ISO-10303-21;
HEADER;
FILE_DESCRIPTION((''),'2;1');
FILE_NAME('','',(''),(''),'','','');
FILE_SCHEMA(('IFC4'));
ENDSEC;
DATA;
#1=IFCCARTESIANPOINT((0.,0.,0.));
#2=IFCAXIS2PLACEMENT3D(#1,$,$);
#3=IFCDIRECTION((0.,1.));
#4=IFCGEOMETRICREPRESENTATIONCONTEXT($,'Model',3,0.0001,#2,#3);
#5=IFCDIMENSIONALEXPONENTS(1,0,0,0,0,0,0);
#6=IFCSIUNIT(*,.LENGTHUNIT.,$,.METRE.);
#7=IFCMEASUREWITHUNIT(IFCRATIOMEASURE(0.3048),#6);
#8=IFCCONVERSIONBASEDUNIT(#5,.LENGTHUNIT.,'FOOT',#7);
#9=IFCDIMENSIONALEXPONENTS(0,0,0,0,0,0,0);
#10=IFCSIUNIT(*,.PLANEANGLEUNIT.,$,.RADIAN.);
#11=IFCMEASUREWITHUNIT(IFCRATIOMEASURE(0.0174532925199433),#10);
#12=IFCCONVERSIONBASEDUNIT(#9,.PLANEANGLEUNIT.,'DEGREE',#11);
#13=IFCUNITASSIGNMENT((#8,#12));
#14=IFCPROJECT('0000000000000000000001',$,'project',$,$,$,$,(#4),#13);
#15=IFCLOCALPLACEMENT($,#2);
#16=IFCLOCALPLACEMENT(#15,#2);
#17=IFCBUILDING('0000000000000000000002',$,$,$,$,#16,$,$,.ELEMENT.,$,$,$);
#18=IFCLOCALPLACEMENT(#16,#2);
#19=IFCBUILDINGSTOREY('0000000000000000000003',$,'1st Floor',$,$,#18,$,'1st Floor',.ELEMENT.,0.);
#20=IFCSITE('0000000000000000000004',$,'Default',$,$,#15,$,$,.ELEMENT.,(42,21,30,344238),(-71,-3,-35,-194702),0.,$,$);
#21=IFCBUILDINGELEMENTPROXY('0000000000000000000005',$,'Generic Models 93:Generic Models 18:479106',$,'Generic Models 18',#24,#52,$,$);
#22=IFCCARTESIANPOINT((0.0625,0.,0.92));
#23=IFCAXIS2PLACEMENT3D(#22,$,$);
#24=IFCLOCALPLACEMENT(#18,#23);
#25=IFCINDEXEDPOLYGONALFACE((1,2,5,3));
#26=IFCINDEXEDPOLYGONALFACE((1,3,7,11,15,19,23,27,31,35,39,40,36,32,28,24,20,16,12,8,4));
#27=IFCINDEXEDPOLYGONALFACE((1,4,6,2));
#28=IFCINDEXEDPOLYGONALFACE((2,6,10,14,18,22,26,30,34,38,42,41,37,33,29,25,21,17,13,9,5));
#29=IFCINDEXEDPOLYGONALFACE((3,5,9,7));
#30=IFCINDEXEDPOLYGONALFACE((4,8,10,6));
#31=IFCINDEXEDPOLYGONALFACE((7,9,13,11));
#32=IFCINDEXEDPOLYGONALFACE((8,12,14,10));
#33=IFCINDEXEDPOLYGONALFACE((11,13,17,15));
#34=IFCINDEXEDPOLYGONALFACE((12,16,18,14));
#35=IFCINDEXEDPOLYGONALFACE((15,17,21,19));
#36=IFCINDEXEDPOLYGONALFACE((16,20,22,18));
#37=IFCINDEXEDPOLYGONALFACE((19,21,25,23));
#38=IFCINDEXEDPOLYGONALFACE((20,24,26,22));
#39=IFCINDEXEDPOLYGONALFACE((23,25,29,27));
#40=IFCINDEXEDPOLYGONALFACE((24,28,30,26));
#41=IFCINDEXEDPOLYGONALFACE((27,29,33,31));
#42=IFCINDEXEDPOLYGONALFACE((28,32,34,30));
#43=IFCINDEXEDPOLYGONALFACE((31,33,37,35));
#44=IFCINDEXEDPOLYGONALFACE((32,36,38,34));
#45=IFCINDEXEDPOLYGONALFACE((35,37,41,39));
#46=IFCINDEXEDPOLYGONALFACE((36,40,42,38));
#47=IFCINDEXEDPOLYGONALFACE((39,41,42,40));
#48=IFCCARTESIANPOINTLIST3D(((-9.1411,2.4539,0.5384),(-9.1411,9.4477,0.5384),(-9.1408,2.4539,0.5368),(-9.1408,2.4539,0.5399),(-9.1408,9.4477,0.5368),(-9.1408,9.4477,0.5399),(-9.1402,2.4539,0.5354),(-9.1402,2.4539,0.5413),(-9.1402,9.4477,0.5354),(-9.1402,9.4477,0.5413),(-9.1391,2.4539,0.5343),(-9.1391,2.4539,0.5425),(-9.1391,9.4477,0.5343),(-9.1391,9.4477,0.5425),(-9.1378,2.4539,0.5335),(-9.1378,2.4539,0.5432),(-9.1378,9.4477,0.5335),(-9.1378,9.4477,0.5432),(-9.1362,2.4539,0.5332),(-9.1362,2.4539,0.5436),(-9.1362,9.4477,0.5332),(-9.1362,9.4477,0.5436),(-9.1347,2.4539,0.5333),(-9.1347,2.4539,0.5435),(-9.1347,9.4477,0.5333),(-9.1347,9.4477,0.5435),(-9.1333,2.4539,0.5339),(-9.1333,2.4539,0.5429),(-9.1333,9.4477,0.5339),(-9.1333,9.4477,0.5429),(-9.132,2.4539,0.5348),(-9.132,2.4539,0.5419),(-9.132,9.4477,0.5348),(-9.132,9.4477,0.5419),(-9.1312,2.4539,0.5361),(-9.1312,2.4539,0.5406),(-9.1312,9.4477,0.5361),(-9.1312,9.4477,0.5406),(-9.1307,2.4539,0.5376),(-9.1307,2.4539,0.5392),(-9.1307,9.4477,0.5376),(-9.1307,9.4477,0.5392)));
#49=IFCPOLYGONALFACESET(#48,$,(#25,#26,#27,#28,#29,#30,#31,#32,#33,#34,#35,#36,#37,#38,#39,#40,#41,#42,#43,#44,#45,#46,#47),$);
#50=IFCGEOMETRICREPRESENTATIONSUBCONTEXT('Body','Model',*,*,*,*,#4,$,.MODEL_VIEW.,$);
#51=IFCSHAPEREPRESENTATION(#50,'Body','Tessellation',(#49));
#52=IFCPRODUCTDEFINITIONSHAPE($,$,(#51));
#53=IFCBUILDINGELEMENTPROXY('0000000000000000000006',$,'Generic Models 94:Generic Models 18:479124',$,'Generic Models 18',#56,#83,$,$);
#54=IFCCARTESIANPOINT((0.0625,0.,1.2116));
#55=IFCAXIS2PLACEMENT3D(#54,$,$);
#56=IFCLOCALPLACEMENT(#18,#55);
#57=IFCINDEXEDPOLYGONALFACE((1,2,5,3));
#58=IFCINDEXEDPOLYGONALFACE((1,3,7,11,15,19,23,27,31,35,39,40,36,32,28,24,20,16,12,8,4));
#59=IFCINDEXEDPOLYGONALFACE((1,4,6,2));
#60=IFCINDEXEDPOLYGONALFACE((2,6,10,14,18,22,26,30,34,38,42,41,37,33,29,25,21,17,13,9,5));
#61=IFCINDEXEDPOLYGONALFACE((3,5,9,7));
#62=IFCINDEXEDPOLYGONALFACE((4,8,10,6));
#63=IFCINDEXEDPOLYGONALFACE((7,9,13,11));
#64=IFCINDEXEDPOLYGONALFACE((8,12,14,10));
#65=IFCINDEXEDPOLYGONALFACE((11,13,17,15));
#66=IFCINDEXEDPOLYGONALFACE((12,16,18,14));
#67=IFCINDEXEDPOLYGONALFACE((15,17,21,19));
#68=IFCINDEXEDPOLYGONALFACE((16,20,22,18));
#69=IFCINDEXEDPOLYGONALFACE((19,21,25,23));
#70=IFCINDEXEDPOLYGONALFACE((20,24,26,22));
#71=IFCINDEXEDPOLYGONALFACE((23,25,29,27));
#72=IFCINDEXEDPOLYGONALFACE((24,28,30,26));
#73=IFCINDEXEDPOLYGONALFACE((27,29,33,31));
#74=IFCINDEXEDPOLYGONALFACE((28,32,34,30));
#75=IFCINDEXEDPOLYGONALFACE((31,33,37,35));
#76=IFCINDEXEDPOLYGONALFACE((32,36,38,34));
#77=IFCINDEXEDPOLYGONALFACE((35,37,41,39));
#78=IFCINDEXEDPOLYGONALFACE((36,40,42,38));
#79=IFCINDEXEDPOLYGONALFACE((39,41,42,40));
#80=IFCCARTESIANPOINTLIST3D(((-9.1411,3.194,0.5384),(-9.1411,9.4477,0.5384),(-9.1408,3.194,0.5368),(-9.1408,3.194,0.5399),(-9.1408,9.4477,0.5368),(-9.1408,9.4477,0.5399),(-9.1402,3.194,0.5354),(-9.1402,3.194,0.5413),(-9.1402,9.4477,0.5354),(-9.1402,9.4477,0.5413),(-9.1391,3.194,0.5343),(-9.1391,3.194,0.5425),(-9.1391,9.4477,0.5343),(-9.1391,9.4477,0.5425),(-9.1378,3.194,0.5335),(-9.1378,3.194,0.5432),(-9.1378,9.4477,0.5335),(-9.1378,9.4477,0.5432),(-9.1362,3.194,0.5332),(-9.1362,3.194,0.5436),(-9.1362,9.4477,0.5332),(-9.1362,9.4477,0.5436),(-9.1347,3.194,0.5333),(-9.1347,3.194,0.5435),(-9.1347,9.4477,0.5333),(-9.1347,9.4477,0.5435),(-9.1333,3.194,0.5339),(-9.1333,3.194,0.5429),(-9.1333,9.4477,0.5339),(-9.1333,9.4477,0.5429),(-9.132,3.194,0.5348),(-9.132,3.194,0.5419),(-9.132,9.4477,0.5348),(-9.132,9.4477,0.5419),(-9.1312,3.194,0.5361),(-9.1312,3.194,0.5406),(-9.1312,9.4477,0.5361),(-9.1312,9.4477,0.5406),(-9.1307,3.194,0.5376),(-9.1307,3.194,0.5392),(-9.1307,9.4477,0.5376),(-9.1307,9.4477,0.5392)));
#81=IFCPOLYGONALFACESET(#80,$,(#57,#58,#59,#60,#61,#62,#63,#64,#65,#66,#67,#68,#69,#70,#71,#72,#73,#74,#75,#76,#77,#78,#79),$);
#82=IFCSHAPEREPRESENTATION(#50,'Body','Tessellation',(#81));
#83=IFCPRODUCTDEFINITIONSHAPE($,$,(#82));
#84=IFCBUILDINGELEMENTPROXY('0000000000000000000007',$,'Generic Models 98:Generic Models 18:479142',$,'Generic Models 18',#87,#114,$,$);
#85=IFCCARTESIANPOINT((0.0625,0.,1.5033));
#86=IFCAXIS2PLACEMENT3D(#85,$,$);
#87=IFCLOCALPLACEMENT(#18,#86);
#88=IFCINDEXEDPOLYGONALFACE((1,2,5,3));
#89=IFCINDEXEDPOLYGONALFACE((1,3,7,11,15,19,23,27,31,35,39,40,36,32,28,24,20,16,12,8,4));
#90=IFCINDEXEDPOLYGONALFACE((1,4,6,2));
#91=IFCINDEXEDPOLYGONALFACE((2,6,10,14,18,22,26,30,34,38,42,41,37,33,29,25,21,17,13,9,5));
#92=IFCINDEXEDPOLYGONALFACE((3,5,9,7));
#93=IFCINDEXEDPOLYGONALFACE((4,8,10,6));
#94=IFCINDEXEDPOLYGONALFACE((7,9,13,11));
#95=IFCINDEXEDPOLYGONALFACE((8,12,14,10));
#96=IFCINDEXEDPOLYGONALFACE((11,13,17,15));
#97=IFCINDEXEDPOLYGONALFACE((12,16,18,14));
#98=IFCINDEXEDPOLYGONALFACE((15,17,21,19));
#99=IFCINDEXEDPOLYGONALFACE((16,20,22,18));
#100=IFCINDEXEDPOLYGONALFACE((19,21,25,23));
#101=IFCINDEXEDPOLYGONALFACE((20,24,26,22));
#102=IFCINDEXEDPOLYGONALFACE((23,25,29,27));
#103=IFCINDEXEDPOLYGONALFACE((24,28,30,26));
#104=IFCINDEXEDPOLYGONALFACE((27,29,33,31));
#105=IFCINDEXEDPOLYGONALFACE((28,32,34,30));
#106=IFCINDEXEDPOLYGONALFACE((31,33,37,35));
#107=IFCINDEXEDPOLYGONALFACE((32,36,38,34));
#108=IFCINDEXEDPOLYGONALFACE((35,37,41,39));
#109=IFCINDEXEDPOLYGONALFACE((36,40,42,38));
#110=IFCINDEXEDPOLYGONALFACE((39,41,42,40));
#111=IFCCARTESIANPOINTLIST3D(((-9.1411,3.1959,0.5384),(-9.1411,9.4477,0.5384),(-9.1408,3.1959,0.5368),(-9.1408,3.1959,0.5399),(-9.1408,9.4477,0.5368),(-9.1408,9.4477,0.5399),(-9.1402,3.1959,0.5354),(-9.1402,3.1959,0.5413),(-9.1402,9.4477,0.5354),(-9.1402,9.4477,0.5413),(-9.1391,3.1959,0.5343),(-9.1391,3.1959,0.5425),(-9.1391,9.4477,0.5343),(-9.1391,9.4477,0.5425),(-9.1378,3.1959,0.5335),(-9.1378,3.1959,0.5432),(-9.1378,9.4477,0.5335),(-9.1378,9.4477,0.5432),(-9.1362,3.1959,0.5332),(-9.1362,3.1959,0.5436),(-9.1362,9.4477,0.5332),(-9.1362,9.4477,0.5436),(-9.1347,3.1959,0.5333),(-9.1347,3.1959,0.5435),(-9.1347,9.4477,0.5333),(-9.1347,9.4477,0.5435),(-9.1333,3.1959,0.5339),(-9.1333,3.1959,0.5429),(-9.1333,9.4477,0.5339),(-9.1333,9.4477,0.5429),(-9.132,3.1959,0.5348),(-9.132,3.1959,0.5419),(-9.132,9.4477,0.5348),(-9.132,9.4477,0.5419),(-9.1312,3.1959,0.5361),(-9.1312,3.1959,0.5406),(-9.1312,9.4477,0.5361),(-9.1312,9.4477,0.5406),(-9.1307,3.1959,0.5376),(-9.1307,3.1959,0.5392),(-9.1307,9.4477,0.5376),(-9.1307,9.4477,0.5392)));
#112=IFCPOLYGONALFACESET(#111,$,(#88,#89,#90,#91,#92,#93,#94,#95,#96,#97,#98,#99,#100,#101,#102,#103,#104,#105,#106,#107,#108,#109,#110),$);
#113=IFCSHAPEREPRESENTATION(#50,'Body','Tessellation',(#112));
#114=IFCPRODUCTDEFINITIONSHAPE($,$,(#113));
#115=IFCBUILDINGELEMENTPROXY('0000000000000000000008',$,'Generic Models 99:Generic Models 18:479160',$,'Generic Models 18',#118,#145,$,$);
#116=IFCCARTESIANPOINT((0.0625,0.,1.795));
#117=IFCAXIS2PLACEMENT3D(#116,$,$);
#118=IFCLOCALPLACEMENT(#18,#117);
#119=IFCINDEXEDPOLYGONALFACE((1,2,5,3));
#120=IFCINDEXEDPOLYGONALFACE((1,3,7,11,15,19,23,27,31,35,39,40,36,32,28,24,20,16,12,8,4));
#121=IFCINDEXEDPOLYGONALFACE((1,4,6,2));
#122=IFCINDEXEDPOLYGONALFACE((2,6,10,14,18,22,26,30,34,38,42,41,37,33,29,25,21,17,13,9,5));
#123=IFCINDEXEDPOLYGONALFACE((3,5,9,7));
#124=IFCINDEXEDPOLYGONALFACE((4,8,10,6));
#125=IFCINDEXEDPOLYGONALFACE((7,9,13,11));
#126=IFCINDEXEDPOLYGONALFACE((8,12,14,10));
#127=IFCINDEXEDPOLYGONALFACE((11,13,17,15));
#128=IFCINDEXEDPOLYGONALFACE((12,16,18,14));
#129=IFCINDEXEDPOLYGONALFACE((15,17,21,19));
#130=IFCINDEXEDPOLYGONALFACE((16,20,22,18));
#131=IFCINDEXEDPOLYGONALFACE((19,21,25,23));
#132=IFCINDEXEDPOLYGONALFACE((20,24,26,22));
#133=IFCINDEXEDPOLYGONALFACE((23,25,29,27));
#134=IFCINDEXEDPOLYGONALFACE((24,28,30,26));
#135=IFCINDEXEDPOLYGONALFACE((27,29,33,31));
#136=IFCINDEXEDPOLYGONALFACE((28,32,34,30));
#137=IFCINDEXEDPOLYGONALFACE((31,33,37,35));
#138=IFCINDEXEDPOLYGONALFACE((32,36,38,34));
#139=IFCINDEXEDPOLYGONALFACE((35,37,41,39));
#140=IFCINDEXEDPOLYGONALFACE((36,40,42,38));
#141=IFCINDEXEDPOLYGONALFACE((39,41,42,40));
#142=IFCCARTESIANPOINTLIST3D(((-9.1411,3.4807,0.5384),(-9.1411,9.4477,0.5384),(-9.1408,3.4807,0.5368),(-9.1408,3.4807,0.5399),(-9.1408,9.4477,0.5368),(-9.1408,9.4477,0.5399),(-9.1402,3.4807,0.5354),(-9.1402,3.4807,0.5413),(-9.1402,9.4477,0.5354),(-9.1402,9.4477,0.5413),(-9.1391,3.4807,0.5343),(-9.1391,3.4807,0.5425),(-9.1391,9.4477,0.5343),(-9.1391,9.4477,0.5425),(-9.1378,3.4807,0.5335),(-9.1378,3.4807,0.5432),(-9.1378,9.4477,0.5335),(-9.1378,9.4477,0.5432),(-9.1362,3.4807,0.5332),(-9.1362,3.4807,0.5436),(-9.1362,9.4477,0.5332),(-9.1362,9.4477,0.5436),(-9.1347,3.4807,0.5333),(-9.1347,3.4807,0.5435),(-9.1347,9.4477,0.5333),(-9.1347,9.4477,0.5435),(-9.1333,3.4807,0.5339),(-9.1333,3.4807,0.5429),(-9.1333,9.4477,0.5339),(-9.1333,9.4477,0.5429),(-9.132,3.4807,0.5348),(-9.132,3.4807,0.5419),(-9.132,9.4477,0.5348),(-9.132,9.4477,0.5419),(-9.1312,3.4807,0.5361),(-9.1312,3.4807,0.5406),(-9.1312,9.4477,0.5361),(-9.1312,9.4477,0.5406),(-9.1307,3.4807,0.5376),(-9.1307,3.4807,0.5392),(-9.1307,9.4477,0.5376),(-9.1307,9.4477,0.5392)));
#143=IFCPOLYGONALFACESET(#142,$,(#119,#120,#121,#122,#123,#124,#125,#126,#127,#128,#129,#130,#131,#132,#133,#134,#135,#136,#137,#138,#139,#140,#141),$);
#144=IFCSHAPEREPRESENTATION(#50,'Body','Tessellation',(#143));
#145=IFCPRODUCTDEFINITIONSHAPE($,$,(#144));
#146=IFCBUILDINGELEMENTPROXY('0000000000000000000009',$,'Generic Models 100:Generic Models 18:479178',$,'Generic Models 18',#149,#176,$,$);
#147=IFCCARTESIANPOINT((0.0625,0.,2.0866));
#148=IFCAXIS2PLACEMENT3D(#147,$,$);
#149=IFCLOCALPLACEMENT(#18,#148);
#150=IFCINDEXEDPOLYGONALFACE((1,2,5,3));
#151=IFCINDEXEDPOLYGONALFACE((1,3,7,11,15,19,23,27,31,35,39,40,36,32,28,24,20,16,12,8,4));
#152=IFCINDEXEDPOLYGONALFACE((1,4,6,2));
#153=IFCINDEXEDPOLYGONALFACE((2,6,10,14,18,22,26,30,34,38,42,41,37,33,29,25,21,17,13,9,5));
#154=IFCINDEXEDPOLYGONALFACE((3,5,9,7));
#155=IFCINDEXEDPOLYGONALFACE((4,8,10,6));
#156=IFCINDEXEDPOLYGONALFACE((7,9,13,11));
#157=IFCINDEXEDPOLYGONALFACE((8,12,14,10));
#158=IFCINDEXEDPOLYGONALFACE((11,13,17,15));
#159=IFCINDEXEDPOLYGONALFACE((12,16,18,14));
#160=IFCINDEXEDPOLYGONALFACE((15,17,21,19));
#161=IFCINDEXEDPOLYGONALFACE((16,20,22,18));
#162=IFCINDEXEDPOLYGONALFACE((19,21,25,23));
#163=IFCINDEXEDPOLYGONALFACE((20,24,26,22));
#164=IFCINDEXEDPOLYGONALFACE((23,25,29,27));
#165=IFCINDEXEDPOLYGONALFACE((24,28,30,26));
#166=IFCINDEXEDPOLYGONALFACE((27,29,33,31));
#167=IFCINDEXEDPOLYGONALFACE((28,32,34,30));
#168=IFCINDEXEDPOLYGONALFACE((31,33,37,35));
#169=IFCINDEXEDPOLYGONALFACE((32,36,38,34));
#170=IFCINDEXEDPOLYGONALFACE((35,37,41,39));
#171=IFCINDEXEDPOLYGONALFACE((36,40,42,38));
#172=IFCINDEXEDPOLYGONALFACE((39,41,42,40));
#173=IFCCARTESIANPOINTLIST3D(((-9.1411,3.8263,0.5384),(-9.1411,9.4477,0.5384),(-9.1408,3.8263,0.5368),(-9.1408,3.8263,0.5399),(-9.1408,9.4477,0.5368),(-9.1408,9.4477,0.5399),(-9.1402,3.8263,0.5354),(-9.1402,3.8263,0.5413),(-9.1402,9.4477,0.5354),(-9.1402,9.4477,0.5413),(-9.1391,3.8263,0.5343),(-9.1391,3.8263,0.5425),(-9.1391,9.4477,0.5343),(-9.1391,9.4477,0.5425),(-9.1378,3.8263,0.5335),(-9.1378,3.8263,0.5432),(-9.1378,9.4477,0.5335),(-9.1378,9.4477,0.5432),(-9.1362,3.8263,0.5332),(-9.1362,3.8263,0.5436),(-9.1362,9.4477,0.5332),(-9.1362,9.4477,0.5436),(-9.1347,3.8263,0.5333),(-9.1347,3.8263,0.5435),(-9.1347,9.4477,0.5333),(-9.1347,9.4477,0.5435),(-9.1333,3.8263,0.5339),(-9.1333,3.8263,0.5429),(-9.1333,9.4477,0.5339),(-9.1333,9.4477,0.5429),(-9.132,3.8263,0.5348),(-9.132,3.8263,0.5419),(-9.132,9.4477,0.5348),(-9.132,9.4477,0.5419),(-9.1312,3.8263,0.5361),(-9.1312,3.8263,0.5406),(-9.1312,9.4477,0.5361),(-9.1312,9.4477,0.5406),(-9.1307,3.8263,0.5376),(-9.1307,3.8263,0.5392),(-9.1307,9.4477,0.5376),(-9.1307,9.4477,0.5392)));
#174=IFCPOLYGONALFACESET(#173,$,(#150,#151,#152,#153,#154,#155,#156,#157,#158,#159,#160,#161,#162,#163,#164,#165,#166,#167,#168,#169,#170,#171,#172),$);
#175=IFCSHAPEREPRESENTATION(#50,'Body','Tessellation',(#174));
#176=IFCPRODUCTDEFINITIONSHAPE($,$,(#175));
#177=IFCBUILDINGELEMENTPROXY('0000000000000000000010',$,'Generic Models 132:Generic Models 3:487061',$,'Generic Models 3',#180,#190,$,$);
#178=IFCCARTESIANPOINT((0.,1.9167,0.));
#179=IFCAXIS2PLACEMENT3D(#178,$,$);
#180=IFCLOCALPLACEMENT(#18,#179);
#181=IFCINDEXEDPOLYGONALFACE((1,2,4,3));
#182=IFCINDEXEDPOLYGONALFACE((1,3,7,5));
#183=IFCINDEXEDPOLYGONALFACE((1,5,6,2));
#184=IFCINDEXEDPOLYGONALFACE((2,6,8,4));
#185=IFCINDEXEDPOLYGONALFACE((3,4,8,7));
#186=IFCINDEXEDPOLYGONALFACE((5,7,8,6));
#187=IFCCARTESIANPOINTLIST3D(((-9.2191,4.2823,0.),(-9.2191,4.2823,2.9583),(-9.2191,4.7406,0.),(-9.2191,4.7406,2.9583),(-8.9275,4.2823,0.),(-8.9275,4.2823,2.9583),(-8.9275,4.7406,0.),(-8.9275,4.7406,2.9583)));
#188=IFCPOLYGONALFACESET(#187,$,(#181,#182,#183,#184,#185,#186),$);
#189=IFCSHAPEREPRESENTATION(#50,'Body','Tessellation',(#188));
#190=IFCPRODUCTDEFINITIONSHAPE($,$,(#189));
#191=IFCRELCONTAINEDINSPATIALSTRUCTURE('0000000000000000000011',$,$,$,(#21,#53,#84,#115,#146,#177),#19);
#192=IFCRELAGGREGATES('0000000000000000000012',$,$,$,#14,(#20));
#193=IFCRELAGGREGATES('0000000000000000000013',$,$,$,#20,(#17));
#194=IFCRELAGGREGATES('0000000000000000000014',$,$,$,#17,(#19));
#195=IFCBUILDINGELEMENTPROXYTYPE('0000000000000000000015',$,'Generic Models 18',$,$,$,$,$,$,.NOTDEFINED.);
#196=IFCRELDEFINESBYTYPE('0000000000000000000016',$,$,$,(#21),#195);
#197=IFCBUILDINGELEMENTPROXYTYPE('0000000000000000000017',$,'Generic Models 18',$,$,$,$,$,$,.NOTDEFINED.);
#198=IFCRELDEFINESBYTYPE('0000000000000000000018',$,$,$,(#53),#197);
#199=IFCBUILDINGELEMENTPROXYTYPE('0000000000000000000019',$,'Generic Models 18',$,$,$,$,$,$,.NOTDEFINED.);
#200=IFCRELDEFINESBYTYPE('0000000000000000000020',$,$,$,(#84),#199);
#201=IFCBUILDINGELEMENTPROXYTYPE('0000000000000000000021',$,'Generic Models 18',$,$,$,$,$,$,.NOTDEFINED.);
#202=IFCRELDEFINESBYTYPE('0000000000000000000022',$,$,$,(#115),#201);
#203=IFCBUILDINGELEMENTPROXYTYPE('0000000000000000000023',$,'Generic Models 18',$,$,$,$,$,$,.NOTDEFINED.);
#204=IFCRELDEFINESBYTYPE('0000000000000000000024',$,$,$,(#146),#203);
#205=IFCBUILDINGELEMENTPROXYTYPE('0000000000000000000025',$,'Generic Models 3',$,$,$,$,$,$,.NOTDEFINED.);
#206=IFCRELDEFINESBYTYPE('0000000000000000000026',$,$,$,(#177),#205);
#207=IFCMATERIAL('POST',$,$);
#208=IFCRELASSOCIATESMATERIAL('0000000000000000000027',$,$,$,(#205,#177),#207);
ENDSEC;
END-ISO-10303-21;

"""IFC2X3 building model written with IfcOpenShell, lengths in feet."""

from ifc_helpers import new_model, entity, si_unit, converted_unit, direction, frame, frame_2d, origin, origin_2d_with_axis, place, context, subcontext, project, spatial, rectangle, circle, extrude, source, transform, mapped, material, type_object, type_shapes, element, save


model = new_model("IFC2X3")

# Units and contexts
model_context = context("Model", 3, precision=0.0001, world=origin(), true_north=direction((0.0, 1.0)))
body_context = subcontext(model_context, "Body", "Model", "MODEL_VIEW")
ifc_project = project(units=[converted_unit("LENGTHUNIT", "FOOT", entity("IfcRatioMeasure", 0.3048), si_unit("LENGTHUNIT", "METRE"), dimensions=[1, 0, 0, 0, 0, 0, 0]), converted_unit("PLANEANGLEUNIT", "DEGREE", entity("IfcRatioMeasure", 0.0174532925199433), si_unit("PLANEANGLEUNIT", "RADIAN"), dimensions=[0, 0, 0, 0, 0, 0, 0])], contexts=[model_context])

# Site, building, storey
site_placement = place(None, origin())
site = spatial("IfcSite", under=ifc_project, at=site_placement, Name="Default", CompositionType="ELEMENT", RefLatitude=(42, 21, 30, 344238), RefLongitude=(-71, -3, -35, -194702), RefElevation=0.0)
building_placement = place(site_placement, origin())
building = spatial("IfcBuilding", under=site, at=building_placement, CompositionType="ELEMENT")
storey_placement = place(building_placement, origin())
storey = spatial("IfcBuildingStorey", under=building, at=storey_placement, Name="1st Floor", LongName="1st Floor", CompositionType="ELEMENT", Elevation=0.0)

# Building element proxies
building_element_proxy_type_1 = type_object("IfcBuildingElementProxyType", Name="Generic Models 18", PredefinedType="NOTDEFINED")
shared_shape_1 = source(origin(), body_context, "Body", "SweptSolid", [
    extrude(circle(Radius=0.0052, at=origin_2d_with_axis()), frame((-9.1359, 2.4539, 0.5384), z_axis=(0.0, 1.0, 0.0), x_axis=(-1.0, 0.0, 0.0)), (0.0, 0.0, 1.0), 6.9938),
])
type_shapes(building_element_proxy_type_1, [shared_shape_1])
proxy_1_placement = place(storey_placement, frame((0.0625, 0.0, 0.92)))
element("IfcBuildingElementProxy", 1, at=proxy_1_placement, inside=storey, type_object=building_element_proxy_type_1, Name="Generic Models 93:Generic Models 18:479106", ObjectType="Generic Models 18", context=body_context, shape_type="MappedRepresentation", body=[
    mapped(shared_shape_1, transform((0.0, 0.0, 0.0), scale=1.0)),
])
building_element_proxy_type_2 = type_object("IfcBuildingElementProxyType", Name="Generic Models 18", PredefinedType="NOTDEFINED")
shared_shape_2 = source(origin(), body_context, "Body", "SweptSolid", [
    extrude(circle(Radius=0.0052, at=origin_2d_with_axis()), frame((-9.1359, 3.194, 0.5384), z_axis=(0.0, 1.0, 0.0), x_axis=(-1.0, 0.0, 0.0)), (0.0, 0.0, 1.0), 6.2537),
])
type_shapes(building_element_proxy_type_2, [shared_shape_2])
proxy_2_placement = place(storey_placement, frame((0.0625, 0.0, 1.2116)))
element("IfcBuildingElementProxy", 2, at=proxy_2_placement, inside=storey, type_object=building_element_proxy_type_2, Name="Generic Models 94:Generic Models 18:479124", ObjectType="Generic Models 18", context=body_context, shape_type="MappedRepresentation", body=[
    mapped(shared_shape_2, transform((0.0, 0.0, 0.0), scale=1.0)),
])
building_element_proxy_type_3 = type_object("IfcBuildingElementProxyType", Name="Generic Models 18", PredefinedType="NOTDEFINED")
shared_shape_3 = source(origin(), body_context, "Body", "SweptSolid", [
    extrude(circle(Radius=0.0052, at=origin_2d_with_axis()), frame((-9.1359, 3.1959, 0.5384), z_axis=(0.0, 1.0, 0.0), x_axis=(-1.0, 0.0, 0.0)), (0.0, 0.0, 1.0), 6.2518),
])
type_shapes(building_element_proxy_type_3, [shared_shape_3])
proxy_3_placement = place(storey_placement, frame((0.0625, 0.0, 1.5033)))
element("IfcBuildingElementProxy", 3, at=proxy_3_placement, inside=storey, type_object=building_element_proxy_type_3, Name="Generic Models 98:Generic Models 18:479142", ObjectType="Generic Models 18", context=body_context, shape_type="MappedRepresentation", body=[
    mapped(shared_shape_3, transform((0.0, 0.0, 0.0), scale=1.0)),
])
building_element_proxy_type_4 = type_object("IfcBuildingElementProxyType", Name="Generic Models 18", PredefinedType="NOTDEFINED")
shared_shape_4 = source(origin(), body_context, "Body", "SweptSolid", [
    extrude(circle(Radius=0.0052, at=origin_2d_with_axis()), frame((-9.1359, 3.4807, 0.5384), z_axis=(0.0, 1.0, 0.0), x_axis=(-1.0, 0.0, 0.0)), (0.0, 0.0, 1.0), 5.967),
])
type_shapes(building_element_proxy_type_4, [shared_shape_4])
proxy_4_placement = place(storey_placement, frame((0.0625, 0.0, 1.795)))
element("IfcBuildingElementProxy", 4, at=proxy_4_placement, inside=storey, type_object=building_element_proxy_type_4, Name="Generic Models 99:Generic Models 18:479160", ObjectType="Generic Models 18", context=body_context, shape_type="MappedRepresentation", body=[
    mapped(shared_shape_4, transform((0.0, 0.0, 0.0), scale=1.0)),
])
building_element_proxy_type_5 = type_object("IfcBuildingElementProxyType", Name="Generic Models 18", PredefinedType="NOTDEFINED")
shared_shape_5 = source(origin(), body_context, "Body", "SweptSolid", [
    extrude(circle(Radius=0.0052, at=origin_2d_with_axis()), frame((-9.1359, 3.8263, 0.5384), z_axis=(0.0, 1.0, 0.0), x_axis=(-1.0, 0.0, 0.0)), (0.0, 0.0, 1.0), 5.6214),
])
type_shapes(building_element_proxy_type_5, [shared_shape_5])
proxy_5_placement = place(storey_placement, frame((0.0625, 0.0, 2.0866)))
element("IfcBuildingElementProxy", 5, at=proxy_5_placement, inside=storey, type_object=building_element_proxy_type_5, Name="Generic Models 100:Generic Models 18:479178", ObjectType="Generic Models 18", context=body_context, shape_type="MappedRepresentation", body=[
    mapped(shared_shape_5, transform((0.0, 0.0, 0.0), scale=1.0)),
])
ifc_material_1 = material(Name="POST")
building_element_proxy_type_6 = type_object("IfcBuildingElementProxyType", Name="Generic Models 3", PredefinedType="NOTDEFINED", material=ifc_material_1)
shared_shape_6 = source(origin(), body_context, "Body", "SweptSolid", [
    extrude(rectangle(XDim=0.2917, YDim=0.4583, at=frame_2d((0.0, 0.0), x_axis=(1.0, 0.0))), frame((-9.0733, 4.5114, 0.0), z_axis=(0.0, 0.0, 1.0), x_axis=(-1.0, 0.0, 0.0)), (0.0, 0.0, 1.0), 2.9583),
])
type_shapes(building_element_proxy_type_6, [shared_shape_6])
proxy_6_placement = place(storey_placement, frame((0.0, 1.9167, 0.0)))
element("IfcBuildingElementProxy", 6, at=proxy_6_placement, inside=storey, type_object=building_element_proxy_type_6, material=ifc_material_1, Name="Generic Models 132:Generic Models 3:487061", ObjectType="Generic Models 3", context=body_context, shape_type="MappedRepresentation", body=[
    mapped(shared_shape_6, transform((0.0, 0.0, 0.0), scale=1.0)),
])

save(model, "model.ifc")
